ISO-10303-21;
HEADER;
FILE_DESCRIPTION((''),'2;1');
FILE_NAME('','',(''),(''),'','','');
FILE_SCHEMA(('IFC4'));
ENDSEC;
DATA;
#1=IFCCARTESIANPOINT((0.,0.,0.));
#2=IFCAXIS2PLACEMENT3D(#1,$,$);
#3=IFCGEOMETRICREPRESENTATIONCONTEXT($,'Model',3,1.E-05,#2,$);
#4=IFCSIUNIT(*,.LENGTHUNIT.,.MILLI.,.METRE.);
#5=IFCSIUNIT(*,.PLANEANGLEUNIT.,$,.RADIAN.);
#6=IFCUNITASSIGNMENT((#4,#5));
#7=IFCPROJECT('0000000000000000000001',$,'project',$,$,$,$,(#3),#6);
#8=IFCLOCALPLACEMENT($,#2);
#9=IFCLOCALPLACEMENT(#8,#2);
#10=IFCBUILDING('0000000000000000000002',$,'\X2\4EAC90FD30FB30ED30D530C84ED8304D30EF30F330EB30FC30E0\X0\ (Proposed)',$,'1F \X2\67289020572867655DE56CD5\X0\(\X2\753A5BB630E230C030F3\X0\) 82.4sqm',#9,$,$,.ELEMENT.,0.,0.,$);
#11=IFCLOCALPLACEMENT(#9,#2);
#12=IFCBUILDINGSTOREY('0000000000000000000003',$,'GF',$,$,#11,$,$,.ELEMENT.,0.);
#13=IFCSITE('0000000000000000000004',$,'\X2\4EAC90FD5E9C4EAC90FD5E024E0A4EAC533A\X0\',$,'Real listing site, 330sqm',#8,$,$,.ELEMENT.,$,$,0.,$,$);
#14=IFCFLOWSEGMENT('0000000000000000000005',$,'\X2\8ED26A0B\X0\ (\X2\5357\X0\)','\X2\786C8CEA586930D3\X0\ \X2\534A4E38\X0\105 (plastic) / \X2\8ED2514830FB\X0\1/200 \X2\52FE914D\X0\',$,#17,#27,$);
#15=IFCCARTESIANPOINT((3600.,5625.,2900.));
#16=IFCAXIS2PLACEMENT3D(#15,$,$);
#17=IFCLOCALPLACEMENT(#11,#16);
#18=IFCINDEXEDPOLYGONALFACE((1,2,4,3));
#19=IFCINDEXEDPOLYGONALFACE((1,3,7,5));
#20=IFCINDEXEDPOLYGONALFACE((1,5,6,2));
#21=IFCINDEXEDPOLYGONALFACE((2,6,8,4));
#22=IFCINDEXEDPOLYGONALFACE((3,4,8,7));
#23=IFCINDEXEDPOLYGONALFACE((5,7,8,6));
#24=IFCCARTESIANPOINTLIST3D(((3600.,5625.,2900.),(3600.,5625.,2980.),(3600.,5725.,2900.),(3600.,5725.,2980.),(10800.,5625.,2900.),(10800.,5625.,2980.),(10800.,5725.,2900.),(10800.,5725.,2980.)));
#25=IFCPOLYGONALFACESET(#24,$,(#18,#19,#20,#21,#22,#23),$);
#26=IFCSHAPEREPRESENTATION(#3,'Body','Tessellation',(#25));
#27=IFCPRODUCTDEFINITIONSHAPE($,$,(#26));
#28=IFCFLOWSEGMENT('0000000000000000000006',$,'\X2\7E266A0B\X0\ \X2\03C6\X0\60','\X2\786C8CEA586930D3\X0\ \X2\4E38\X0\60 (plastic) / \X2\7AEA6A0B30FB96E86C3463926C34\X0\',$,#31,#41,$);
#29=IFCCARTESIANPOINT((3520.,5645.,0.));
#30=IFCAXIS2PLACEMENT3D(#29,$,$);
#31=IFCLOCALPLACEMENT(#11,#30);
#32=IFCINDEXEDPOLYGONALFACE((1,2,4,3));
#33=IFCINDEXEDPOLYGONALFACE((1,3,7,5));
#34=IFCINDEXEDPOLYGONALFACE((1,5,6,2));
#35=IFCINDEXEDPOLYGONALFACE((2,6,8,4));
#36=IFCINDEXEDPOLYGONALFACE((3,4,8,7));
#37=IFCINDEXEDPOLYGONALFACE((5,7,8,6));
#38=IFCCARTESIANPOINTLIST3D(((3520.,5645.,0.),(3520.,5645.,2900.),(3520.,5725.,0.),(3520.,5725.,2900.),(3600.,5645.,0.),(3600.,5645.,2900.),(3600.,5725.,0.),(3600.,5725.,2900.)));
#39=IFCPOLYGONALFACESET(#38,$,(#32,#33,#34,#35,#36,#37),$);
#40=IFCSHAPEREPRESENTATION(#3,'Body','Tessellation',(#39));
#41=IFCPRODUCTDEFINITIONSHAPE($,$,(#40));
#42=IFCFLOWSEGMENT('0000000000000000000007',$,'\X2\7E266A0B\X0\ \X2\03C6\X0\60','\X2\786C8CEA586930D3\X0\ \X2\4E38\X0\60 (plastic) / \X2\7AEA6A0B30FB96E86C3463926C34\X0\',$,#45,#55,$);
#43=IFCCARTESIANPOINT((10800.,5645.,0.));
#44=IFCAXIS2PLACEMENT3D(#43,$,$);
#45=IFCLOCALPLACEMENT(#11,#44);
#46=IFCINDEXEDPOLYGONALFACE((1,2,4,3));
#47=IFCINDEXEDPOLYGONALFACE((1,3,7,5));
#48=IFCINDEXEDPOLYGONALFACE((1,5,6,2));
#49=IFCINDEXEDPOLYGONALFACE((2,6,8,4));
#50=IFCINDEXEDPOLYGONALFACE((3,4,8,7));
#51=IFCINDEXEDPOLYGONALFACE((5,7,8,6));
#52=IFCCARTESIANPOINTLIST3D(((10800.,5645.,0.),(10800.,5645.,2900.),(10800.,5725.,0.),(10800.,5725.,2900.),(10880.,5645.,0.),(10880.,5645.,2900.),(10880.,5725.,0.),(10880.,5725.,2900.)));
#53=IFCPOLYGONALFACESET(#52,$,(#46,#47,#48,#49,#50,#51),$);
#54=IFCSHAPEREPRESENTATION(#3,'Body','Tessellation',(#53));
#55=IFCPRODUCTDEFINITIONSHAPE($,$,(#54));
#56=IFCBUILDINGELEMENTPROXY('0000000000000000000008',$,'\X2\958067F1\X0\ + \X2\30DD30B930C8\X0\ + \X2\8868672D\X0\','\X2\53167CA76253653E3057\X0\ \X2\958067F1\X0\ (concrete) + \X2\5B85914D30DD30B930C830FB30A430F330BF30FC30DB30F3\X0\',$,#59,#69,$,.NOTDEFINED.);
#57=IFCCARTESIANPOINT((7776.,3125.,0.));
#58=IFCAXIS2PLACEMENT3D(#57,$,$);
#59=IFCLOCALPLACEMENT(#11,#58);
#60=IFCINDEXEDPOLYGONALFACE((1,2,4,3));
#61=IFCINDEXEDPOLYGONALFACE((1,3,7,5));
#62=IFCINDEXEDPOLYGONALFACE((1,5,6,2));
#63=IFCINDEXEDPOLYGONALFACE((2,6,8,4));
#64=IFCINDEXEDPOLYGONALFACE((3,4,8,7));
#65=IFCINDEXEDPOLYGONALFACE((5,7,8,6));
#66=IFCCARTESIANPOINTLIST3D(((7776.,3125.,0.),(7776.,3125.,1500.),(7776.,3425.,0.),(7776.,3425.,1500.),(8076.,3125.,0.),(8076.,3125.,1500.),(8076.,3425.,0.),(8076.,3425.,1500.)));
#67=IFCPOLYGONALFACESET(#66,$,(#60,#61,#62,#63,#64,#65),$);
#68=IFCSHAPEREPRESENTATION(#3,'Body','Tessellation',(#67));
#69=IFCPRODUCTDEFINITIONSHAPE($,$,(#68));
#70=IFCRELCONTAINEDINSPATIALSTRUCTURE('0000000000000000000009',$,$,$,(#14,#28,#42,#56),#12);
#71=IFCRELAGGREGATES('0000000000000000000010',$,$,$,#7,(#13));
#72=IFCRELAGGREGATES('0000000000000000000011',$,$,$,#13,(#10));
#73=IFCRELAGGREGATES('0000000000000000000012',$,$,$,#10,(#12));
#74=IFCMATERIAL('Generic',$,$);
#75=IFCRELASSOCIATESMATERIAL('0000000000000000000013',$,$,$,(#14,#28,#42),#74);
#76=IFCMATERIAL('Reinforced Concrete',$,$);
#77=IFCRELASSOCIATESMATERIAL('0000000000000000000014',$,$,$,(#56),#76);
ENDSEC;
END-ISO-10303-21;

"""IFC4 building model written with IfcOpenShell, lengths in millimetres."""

from ifc_helpers import new_model, si_unit, frame, frame_2d, origin, place, context, project, spatial, rectangle, extrude, material, element, save


model = new_model("IFC4")

# Units and contexts
model_context = context("Model", 3, precision=1e-05, world=origin())
ifc_project = project(units=[si_unit("LENGTHUNIT", "METRE", prefix="MILLI"), si_unit("PLANEANGLEUNIT", "RADIAN")], contexts=[model_context])

# Site, building, storey
site_placement = place(None, origin())
site = spatial("IfcSite", under=ifc_project, at=site_placement, Name="京都府京都市上京区", ObjectType="Real listing site, 330sqm", CompositionType="ELEMENT", RefElevation=0.0)
building_placement = place(site_placement, origin())
building = spatial("IfcBuilding", under=site, at=building_placement, Name="京都・ロフト付きワンルーム (Proposed)", ObjectType="1F 木造在来工法(町家モダン) 82.4sqm", CompositionType="ELEMENT", ElevationOfRefHeight=0.0, ElevationOfTerrain=0.0)
storey_placement = place(building_placement, origin())
storey = spatial("IfcBuildingStorey", under=building, at=storey_placement, Name="GF", CompositionType="ELEMENT", Elevation=0.0)

# Shared definitions
ifc_material_1 = material(Name="Reinforced Concrete")

# Flow segments
ifc_material_2 = material(Name="Generic")
flow_segment_1_placement = place(storey_placement, frame((3600.0, 5625.0, 2900.0)))
element("IfcFlowSegment", 1, at=flow_segment_1_placement, inside=storey, material=ifc_material_2, Name="軒樋 (南)", Description="硬質塩ビ 半丸105 (plastic) / 軒先・1/200 勾配", context=model_context, shape_type="SweptSolid", body=[
    extrude(rectangle(XDim=7200.0, YDim=100.0, at=frame_2d((3600.0, 50.0))), frame((3600.0, 5625.0, 2900.0)), (0.0, 0.0, 1.0), 80.0),
])
flow_segment_2_placement = place(storey_placement, frame((3520.0, 5645.0, 0.0)))
element("IfcFlowSegment", 2, at=flow_segment_2_placement, inside=storey, material=ifc_material_2, Name="縦樋 φ60", Description="硬質塩ビ 丸60 (plastic) / 竪樋・雨水排水", context=model_context, shape_type="SweptSolid", body=[
    extrude(rectangle(XDim=80.0, YDim=80.0, at=frame_2d((40.0, 40.0))), frame((3520.0, 5645.0, 0.0)), (0.0, 0.0, 1.0), 2900.0),
])
flow_segment_3_placement = place(storey_placement, frame((10800.0, 5645.0, 0.0)))
element("IfcFlowSegment", 3, at=flow_segment_3_placement, inside=storey, material=ifc_material_2, Name="縦樋 φ60", Description="硬質塩ビ 丸60 (plastic) / 竪樋・雨水排水", context=model_context, shape_type="SweptSolid", body=[
    extrude(rectangle(XDim=80.0, YDim=80.0, at=frame_2d((40.0, 40.0))), frame((10800.0, 5645.0, 0.0)), (0.0, 0.0, 1.0), 2900.0),
])

# Building element proxy
proxy_placement = place(storey_placement, frame((7776.0, 3125.0, 0.0)))
element("IfcBuildingElementProxy", 4, at=proxy_placement, inside=storey, material=ifc_material_1, Name="門柱 + ポスト + 表札", Description="化粧打放し 門柱 (concrete) + 宅配ポスト・インターホン", PredefinedType="NOTDEFINED", context=model_context, shape_type="SweptSolid", body=[
    extrude(rectangle(XDim=300.0, YDim=300.0, at=frame_2d((150.0, 150.0))), frame((7776.0, 3125.0, 0.0)), (0.0, 0.0, 1.0), 1500.0),
])

save(model, "model.ifc")
